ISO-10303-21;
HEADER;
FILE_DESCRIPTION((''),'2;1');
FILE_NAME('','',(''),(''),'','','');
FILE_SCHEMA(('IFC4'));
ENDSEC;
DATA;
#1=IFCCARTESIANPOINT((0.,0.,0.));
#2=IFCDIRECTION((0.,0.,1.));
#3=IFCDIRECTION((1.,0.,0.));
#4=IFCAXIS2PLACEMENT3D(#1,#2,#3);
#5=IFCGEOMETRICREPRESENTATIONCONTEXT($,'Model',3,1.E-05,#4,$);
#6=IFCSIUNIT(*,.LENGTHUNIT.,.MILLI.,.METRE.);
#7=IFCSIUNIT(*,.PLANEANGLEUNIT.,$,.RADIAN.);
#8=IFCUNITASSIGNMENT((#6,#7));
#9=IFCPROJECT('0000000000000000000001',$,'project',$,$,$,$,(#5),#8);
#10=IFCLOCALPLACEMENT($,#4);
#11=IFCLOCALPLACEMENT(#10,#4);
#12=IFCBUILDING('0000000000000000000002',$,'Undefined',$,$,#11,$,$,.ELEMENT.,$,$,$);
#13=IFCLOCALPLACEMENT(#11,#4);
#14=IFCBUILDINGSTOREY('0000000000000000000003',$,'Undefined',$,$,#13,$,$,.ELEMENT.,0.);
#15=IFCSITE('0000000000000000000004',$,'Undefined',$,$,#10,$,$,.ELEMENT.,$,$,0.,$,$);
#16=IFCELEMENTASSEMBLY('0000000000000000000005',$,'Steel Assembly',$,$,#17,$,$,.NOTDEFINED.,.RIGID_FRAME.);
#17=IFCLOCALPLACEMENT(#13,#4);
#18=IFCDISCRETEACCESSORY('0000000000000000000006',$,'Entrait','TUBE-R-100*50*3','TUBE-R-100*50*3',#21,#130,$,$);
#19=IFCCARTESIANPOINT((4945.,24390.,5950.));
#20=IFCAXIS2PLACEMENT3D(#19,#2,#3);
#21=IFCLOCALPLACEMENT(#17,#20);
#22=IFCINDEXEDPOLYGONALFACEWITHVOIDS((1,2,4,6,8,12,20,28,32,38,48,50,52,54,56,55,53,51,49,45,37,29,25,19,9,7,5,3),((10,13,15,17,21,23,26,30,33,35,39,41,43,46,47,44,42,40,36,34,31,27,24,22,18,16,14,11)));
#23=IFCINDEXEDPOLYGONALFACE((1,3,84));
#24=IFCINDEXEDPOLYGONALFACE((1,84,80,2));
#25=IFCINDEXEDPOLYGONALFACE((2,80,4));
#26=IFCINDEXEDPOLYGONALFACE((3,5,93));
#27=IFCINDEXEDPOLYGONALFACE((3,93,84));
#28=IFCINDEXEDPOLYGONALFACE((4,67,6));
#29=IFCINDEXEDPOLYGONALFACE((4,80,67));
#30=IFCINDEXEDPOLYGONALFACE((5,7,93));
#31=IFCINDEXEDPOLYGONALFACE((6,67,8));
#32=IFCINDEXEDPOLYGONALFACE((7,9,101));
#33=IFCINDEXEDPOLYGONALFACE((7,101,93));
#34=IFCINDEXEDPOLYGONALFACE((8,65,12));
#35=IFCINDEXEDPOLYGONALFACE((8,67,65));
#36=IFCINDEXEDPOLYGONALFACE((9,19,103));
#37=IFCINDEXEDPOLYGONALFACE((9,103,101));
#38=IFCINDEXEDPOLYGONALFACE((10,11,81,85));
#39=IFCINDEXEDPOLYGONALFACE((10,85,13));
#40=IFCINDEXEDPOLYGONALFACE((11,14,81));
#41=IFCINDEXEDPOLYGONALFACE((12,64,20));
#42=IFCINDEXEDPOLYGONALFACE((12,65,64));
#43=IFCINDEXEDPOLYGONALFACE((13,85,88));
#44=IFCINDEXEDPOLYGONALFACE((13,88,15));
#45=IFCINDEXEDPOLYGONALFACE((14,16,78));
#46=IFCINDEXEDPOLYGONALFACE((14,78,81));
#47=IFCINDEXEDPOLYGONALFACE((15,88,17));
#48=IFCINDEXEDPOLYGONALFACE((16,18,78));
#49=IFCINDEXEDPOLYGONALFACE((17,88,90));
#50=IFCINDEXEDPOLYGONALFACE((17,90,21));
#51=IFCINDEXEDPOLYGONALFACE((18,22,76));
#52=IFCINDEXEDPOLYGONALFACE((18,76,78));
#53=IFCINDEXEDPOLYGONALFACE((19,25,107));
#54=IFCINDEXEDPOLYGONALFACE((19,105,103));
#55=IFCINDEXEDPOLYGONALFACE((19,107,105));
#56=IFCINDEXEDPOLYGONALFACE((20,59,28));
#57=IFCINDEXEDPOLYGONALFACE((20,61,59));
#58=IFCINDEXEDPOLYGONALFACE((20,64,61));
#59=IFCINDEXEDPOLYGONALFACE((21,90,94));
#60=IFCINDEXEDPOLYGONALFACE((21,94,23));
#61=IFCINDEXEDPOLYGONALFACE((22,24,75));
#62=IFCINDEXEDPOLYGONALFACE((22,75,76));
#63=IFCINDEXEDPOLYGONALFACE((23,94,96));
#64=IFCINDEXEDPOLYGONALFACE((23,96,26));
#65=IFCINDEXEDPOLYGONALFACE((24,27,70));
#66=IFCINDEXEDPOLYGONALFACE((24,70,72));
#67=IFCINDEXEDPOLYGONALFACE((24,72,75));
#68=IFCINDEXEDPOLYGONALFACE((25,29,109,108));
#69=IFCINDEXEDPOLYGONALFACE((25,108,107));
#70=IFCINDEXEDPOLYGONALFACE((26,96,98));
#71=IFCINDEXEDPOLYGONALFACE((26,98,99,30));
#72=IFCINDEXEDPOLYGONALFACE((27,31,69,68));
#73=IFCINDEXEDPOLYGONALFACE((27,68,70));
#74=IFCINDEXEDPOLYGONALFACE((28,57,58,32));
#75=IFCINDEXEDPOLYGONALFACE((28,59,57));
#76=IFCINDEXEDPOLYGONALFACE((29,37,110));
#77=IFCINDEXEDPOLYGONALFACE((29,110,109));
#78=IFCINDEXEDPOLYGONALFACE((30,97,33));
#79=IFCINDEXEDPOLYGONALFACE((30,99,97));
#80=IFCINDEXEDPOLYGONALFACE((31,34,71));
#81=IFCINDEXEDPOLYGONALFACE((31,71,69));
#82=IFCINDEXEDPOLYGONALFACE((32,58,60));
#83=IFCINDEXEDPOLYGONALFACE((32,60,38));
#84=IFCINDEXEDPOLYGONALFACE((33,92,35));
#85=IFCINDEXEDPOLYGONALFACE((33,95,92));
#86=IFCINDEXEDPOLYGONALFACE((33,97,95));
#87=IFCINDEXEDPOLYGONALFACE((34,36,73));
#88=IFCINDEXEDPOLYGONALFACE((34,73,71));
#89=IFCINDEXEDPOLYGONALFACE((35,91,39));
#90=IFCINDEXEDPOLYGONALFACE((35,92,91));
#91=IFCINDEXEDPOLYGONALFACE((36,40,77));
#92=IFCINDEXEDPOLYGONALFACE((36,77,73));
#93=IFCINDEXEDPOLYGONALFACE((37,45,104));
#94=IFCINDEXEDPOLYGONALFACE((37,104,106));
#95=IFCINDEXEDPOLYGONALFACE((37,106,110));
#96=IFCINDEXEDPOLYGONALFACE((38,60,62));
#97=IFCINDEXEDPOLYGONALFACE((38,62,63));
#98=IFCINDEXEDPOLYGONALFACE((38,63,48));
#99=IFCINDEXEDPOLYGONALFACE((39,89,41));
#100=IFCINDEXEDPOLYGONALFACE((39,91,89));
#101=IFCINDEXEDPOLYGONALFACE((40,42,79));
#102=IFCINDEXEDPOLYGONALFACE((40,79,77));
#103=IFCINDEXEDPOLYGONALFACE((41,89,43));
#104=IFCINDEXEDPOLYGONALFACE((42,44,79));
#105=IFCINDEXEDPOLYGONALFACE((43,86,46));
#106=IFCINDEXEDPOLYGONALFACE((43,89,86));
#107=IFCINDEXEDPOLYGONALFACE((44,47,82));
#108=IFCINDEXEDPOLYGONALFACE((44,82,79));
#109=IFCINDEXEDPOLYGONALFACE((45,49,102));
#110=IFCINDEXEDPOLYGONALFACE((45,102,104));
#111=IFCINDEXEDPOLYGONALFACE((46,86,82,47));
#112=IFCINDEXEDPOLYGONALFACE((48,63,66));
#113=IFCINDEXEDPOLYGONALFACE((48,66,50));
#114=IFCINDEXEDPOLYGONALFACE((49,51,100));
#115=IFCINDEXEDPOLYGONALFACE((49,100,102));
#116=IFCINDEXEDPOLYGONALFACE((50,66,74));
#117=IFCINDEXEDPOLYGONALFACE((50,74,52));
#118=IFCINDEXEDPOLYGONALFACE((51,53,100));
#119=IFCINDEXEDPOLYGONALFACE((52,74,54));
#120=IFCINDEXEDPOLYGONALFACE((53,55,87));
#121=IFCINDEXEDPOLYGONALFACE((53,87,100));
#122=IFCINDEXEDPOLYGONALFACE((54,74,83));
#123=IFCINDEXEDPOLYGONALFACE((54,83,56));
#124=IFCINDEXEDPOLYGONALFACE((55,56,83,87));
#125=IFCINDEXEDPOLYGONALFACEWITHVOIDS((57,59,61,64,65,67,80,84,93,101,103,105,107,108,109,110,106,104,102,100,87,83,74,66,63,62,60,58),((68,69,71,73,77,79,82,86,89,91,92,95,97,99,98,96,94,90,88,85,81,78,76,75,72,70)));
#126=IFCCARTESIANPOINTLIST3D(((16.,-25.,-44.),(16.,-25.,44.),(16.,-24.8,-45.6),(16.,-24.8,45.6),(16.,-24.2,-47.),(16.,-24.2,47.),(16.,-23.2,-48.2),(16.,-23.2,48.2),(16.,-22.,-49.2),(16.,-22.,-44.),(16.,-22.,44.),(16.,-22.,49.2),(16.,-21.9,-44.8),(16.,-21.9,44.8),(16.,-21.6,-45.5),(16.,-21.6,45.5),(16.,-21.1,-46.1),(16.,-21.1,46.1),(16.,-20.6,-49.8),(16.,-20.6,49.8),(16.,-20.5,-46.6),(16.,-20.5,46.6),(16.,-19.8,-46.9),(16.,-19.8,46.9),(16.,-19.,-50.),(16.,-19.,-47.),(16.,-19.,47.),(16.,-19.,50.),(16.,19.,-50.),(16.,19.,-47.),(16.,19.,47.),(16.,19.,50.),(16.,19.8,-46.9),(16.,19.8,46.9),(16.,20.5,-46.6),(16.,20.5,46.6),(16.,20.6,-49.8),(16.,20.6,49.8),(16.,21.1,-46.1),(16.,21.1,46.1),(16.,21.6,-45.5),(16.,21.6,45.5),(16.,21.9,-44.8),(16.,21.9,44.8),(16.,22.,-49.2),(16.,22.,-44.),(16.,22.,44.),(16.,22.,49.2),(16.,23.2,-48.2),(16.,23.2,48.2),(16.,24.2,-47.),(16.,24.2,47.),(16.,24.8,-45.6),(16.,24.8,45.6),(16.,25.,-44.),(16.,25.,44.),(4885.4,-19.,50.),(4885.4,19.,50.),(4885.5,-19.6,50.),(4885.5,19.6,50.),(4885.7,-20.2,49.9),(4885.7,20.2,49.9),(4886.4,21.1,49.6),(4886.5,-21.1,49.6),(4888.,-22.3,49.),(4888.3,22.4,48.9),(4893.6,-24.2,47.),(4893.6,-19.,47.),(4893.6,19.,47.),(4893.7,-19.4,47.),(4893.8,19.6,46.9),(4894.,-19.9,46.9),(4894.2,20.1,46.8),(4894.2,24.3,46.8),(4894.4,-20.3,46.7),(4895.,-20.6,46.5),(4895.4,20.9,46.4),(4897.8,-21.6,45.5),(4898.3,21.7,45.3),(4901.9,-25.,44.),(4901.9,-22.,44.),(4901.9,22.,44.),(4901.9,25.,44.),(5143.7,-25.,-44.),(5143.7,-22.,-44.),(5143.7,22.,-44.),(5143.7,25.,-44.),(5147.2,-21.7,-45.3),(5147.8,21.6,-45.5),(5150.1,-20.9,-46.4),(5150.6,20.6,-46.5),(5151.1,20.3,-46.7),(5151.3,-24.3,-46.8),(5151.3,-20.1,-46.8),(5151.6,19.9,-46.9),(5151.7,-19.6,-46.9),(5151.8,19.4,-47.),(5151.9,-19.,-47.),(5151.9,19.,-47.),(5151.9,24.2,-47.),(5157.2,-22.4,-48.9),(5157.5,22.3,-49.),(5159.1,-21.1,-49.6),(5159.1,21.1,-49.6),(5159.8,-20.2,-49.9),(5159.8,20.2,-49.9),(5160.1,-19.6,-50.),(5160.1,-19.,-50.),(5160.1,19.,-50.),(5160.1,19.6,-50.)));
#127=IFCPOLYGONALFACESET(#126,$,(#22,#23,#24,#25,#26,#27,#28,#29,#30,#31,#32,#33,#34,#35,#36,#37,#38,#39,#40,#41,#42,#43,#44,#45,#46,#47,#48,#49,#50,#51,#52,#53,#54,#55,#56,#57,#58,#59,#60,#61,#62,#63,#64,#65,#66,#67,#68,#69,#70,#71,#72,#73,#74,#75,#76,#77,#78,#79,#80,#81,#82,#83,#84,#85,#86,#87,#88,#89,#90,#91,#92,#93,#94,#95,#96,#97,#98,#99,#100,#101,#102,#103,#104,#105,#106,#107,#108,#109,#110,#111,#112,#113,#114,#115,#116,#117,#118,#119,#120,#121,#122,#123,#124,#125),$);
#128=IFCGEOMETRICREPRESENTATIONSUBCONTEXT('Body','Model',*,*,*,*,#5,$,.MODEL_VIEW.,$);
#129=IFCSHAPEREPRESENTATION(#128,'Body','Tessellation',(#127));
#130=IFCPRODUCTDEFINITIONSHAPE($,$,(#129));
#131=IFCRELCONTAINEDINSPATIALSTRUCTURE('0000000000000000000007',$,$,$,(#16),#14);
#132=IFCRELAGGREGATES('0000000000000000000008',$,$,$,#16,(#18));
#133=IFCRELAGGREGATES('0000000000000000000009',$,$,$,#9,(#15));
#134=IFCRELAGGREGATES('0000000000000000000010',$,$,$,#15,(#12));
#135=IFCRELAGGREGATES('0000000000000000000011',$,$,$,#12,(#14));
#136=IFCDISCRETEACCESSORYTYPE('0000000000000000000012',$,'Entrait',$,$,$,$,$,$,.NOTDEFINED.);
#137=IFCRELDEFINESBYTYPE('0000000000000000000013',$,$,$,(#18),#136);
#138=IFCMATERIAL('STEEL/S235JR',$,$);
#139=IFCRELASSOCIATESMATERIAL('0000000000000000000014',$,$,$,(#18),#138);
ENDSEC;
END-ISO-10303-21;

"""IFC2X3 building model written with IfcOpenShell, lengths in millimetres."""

from ifc_helpers import new_model, si_unit, frame, origin_with_axes, origin_2d_with_axis, place, context, subcontext, project, spatial, hollow_rectangle, extrude, clip, halfspace, material, type_object, element, aggregate, save


model = new_model("IFC2X3")

# Units and contexts
model_context = context("Model", 3, precision=1e-05, world=origin_with_axes())
body_context = subcontext(model_context, "Body", "Model", "MODEL_VIEW")
ifc_project = project(units=[si_unit("LENGTHUNIT", "METRE", prefix="MILLI"), si_unit("PLANEANGLEUNIT", "RADIAN")], contexts=[model_context])

# Site, building, storey
site_placement = place(None, origin_with_axes())
site = spatial("IfcSite", under=ifc_project, at=site_placement, Name="Undefined", CompositionType="ELEMENT", RefElevation=0.0)
building_placement = place(site_placement, origin_with_axes())
building = spatial("IfcBuilding", under=site, at=building_placement, Name="Undefined", CompositionType="ELEMENT")
storey_placement = place(building_placement, origin_with_axes())
storey = spatial("IfcBuildingStorey", under=building, at=storey_placement, Name="Undefined", CompositionType="ELEMENT", Elevation=0.0)

# Shared definitions
ifc_material_1 = material(Name="STEEL/S235JR")

# Element assembly
assembly_1_placement = place(storey_placement, origin_with_axes())
assembly_1 = element("IfcElementAssembly", 1, at=assembly_1_placement, inside=storey, Name="Steel Assembly", AssemblyPlace="NOTDEFINED", PredefinedType="RIGID_FRAME")

# Discrete accessory
discrete_accessory_type_1 = type_object("IfcDiscreteAccessoryType", Name="Entrait")
discrete_accessory_1_placement = place(assembly_1_placement, frame((4945.0, 24390.0, 5950.0), z_axis=(0.0, 0.0, 1.0), x_axis=(1.0, 0.0, 0.0)))
discrete_accessory_1 = element("IfcDiscreteAccessory", 2, at=discrete_accessory_1_placement, type_object=discrete_accessory_type_1, material=ifc_material_1, Name="Entrait", Description="TUBE-R-100*50*3", ObjectType="TUBE-R-100*50*3", context=body_context, shape_type="Clipping", body=[
    clip(extrude(hollow_rectangle(XDim=50.0, YDim=100.0, WallThickness=3.0, InnerFilletRadius=3.0, OuterFilletRadius=6.0, at=origin_2d_with_axis()), frame((5161.5, 0.0, 0.0), z_axis=(-1.0, 0.0, 0.0), x_axis=(0.0, -1.0, 0.0)), (0.0, 0.0, 1.0), 5145.5), halfspace(frame((5013.1, 0.0, 3.5), z_axis=(-0.34202, 0.0, -0.939693), x_axis=(0.0, -1.0, 0.0)), True)),
])
aggregate(assembly_1, [discrete_accessory_1])

save(model, "model.ifc")
